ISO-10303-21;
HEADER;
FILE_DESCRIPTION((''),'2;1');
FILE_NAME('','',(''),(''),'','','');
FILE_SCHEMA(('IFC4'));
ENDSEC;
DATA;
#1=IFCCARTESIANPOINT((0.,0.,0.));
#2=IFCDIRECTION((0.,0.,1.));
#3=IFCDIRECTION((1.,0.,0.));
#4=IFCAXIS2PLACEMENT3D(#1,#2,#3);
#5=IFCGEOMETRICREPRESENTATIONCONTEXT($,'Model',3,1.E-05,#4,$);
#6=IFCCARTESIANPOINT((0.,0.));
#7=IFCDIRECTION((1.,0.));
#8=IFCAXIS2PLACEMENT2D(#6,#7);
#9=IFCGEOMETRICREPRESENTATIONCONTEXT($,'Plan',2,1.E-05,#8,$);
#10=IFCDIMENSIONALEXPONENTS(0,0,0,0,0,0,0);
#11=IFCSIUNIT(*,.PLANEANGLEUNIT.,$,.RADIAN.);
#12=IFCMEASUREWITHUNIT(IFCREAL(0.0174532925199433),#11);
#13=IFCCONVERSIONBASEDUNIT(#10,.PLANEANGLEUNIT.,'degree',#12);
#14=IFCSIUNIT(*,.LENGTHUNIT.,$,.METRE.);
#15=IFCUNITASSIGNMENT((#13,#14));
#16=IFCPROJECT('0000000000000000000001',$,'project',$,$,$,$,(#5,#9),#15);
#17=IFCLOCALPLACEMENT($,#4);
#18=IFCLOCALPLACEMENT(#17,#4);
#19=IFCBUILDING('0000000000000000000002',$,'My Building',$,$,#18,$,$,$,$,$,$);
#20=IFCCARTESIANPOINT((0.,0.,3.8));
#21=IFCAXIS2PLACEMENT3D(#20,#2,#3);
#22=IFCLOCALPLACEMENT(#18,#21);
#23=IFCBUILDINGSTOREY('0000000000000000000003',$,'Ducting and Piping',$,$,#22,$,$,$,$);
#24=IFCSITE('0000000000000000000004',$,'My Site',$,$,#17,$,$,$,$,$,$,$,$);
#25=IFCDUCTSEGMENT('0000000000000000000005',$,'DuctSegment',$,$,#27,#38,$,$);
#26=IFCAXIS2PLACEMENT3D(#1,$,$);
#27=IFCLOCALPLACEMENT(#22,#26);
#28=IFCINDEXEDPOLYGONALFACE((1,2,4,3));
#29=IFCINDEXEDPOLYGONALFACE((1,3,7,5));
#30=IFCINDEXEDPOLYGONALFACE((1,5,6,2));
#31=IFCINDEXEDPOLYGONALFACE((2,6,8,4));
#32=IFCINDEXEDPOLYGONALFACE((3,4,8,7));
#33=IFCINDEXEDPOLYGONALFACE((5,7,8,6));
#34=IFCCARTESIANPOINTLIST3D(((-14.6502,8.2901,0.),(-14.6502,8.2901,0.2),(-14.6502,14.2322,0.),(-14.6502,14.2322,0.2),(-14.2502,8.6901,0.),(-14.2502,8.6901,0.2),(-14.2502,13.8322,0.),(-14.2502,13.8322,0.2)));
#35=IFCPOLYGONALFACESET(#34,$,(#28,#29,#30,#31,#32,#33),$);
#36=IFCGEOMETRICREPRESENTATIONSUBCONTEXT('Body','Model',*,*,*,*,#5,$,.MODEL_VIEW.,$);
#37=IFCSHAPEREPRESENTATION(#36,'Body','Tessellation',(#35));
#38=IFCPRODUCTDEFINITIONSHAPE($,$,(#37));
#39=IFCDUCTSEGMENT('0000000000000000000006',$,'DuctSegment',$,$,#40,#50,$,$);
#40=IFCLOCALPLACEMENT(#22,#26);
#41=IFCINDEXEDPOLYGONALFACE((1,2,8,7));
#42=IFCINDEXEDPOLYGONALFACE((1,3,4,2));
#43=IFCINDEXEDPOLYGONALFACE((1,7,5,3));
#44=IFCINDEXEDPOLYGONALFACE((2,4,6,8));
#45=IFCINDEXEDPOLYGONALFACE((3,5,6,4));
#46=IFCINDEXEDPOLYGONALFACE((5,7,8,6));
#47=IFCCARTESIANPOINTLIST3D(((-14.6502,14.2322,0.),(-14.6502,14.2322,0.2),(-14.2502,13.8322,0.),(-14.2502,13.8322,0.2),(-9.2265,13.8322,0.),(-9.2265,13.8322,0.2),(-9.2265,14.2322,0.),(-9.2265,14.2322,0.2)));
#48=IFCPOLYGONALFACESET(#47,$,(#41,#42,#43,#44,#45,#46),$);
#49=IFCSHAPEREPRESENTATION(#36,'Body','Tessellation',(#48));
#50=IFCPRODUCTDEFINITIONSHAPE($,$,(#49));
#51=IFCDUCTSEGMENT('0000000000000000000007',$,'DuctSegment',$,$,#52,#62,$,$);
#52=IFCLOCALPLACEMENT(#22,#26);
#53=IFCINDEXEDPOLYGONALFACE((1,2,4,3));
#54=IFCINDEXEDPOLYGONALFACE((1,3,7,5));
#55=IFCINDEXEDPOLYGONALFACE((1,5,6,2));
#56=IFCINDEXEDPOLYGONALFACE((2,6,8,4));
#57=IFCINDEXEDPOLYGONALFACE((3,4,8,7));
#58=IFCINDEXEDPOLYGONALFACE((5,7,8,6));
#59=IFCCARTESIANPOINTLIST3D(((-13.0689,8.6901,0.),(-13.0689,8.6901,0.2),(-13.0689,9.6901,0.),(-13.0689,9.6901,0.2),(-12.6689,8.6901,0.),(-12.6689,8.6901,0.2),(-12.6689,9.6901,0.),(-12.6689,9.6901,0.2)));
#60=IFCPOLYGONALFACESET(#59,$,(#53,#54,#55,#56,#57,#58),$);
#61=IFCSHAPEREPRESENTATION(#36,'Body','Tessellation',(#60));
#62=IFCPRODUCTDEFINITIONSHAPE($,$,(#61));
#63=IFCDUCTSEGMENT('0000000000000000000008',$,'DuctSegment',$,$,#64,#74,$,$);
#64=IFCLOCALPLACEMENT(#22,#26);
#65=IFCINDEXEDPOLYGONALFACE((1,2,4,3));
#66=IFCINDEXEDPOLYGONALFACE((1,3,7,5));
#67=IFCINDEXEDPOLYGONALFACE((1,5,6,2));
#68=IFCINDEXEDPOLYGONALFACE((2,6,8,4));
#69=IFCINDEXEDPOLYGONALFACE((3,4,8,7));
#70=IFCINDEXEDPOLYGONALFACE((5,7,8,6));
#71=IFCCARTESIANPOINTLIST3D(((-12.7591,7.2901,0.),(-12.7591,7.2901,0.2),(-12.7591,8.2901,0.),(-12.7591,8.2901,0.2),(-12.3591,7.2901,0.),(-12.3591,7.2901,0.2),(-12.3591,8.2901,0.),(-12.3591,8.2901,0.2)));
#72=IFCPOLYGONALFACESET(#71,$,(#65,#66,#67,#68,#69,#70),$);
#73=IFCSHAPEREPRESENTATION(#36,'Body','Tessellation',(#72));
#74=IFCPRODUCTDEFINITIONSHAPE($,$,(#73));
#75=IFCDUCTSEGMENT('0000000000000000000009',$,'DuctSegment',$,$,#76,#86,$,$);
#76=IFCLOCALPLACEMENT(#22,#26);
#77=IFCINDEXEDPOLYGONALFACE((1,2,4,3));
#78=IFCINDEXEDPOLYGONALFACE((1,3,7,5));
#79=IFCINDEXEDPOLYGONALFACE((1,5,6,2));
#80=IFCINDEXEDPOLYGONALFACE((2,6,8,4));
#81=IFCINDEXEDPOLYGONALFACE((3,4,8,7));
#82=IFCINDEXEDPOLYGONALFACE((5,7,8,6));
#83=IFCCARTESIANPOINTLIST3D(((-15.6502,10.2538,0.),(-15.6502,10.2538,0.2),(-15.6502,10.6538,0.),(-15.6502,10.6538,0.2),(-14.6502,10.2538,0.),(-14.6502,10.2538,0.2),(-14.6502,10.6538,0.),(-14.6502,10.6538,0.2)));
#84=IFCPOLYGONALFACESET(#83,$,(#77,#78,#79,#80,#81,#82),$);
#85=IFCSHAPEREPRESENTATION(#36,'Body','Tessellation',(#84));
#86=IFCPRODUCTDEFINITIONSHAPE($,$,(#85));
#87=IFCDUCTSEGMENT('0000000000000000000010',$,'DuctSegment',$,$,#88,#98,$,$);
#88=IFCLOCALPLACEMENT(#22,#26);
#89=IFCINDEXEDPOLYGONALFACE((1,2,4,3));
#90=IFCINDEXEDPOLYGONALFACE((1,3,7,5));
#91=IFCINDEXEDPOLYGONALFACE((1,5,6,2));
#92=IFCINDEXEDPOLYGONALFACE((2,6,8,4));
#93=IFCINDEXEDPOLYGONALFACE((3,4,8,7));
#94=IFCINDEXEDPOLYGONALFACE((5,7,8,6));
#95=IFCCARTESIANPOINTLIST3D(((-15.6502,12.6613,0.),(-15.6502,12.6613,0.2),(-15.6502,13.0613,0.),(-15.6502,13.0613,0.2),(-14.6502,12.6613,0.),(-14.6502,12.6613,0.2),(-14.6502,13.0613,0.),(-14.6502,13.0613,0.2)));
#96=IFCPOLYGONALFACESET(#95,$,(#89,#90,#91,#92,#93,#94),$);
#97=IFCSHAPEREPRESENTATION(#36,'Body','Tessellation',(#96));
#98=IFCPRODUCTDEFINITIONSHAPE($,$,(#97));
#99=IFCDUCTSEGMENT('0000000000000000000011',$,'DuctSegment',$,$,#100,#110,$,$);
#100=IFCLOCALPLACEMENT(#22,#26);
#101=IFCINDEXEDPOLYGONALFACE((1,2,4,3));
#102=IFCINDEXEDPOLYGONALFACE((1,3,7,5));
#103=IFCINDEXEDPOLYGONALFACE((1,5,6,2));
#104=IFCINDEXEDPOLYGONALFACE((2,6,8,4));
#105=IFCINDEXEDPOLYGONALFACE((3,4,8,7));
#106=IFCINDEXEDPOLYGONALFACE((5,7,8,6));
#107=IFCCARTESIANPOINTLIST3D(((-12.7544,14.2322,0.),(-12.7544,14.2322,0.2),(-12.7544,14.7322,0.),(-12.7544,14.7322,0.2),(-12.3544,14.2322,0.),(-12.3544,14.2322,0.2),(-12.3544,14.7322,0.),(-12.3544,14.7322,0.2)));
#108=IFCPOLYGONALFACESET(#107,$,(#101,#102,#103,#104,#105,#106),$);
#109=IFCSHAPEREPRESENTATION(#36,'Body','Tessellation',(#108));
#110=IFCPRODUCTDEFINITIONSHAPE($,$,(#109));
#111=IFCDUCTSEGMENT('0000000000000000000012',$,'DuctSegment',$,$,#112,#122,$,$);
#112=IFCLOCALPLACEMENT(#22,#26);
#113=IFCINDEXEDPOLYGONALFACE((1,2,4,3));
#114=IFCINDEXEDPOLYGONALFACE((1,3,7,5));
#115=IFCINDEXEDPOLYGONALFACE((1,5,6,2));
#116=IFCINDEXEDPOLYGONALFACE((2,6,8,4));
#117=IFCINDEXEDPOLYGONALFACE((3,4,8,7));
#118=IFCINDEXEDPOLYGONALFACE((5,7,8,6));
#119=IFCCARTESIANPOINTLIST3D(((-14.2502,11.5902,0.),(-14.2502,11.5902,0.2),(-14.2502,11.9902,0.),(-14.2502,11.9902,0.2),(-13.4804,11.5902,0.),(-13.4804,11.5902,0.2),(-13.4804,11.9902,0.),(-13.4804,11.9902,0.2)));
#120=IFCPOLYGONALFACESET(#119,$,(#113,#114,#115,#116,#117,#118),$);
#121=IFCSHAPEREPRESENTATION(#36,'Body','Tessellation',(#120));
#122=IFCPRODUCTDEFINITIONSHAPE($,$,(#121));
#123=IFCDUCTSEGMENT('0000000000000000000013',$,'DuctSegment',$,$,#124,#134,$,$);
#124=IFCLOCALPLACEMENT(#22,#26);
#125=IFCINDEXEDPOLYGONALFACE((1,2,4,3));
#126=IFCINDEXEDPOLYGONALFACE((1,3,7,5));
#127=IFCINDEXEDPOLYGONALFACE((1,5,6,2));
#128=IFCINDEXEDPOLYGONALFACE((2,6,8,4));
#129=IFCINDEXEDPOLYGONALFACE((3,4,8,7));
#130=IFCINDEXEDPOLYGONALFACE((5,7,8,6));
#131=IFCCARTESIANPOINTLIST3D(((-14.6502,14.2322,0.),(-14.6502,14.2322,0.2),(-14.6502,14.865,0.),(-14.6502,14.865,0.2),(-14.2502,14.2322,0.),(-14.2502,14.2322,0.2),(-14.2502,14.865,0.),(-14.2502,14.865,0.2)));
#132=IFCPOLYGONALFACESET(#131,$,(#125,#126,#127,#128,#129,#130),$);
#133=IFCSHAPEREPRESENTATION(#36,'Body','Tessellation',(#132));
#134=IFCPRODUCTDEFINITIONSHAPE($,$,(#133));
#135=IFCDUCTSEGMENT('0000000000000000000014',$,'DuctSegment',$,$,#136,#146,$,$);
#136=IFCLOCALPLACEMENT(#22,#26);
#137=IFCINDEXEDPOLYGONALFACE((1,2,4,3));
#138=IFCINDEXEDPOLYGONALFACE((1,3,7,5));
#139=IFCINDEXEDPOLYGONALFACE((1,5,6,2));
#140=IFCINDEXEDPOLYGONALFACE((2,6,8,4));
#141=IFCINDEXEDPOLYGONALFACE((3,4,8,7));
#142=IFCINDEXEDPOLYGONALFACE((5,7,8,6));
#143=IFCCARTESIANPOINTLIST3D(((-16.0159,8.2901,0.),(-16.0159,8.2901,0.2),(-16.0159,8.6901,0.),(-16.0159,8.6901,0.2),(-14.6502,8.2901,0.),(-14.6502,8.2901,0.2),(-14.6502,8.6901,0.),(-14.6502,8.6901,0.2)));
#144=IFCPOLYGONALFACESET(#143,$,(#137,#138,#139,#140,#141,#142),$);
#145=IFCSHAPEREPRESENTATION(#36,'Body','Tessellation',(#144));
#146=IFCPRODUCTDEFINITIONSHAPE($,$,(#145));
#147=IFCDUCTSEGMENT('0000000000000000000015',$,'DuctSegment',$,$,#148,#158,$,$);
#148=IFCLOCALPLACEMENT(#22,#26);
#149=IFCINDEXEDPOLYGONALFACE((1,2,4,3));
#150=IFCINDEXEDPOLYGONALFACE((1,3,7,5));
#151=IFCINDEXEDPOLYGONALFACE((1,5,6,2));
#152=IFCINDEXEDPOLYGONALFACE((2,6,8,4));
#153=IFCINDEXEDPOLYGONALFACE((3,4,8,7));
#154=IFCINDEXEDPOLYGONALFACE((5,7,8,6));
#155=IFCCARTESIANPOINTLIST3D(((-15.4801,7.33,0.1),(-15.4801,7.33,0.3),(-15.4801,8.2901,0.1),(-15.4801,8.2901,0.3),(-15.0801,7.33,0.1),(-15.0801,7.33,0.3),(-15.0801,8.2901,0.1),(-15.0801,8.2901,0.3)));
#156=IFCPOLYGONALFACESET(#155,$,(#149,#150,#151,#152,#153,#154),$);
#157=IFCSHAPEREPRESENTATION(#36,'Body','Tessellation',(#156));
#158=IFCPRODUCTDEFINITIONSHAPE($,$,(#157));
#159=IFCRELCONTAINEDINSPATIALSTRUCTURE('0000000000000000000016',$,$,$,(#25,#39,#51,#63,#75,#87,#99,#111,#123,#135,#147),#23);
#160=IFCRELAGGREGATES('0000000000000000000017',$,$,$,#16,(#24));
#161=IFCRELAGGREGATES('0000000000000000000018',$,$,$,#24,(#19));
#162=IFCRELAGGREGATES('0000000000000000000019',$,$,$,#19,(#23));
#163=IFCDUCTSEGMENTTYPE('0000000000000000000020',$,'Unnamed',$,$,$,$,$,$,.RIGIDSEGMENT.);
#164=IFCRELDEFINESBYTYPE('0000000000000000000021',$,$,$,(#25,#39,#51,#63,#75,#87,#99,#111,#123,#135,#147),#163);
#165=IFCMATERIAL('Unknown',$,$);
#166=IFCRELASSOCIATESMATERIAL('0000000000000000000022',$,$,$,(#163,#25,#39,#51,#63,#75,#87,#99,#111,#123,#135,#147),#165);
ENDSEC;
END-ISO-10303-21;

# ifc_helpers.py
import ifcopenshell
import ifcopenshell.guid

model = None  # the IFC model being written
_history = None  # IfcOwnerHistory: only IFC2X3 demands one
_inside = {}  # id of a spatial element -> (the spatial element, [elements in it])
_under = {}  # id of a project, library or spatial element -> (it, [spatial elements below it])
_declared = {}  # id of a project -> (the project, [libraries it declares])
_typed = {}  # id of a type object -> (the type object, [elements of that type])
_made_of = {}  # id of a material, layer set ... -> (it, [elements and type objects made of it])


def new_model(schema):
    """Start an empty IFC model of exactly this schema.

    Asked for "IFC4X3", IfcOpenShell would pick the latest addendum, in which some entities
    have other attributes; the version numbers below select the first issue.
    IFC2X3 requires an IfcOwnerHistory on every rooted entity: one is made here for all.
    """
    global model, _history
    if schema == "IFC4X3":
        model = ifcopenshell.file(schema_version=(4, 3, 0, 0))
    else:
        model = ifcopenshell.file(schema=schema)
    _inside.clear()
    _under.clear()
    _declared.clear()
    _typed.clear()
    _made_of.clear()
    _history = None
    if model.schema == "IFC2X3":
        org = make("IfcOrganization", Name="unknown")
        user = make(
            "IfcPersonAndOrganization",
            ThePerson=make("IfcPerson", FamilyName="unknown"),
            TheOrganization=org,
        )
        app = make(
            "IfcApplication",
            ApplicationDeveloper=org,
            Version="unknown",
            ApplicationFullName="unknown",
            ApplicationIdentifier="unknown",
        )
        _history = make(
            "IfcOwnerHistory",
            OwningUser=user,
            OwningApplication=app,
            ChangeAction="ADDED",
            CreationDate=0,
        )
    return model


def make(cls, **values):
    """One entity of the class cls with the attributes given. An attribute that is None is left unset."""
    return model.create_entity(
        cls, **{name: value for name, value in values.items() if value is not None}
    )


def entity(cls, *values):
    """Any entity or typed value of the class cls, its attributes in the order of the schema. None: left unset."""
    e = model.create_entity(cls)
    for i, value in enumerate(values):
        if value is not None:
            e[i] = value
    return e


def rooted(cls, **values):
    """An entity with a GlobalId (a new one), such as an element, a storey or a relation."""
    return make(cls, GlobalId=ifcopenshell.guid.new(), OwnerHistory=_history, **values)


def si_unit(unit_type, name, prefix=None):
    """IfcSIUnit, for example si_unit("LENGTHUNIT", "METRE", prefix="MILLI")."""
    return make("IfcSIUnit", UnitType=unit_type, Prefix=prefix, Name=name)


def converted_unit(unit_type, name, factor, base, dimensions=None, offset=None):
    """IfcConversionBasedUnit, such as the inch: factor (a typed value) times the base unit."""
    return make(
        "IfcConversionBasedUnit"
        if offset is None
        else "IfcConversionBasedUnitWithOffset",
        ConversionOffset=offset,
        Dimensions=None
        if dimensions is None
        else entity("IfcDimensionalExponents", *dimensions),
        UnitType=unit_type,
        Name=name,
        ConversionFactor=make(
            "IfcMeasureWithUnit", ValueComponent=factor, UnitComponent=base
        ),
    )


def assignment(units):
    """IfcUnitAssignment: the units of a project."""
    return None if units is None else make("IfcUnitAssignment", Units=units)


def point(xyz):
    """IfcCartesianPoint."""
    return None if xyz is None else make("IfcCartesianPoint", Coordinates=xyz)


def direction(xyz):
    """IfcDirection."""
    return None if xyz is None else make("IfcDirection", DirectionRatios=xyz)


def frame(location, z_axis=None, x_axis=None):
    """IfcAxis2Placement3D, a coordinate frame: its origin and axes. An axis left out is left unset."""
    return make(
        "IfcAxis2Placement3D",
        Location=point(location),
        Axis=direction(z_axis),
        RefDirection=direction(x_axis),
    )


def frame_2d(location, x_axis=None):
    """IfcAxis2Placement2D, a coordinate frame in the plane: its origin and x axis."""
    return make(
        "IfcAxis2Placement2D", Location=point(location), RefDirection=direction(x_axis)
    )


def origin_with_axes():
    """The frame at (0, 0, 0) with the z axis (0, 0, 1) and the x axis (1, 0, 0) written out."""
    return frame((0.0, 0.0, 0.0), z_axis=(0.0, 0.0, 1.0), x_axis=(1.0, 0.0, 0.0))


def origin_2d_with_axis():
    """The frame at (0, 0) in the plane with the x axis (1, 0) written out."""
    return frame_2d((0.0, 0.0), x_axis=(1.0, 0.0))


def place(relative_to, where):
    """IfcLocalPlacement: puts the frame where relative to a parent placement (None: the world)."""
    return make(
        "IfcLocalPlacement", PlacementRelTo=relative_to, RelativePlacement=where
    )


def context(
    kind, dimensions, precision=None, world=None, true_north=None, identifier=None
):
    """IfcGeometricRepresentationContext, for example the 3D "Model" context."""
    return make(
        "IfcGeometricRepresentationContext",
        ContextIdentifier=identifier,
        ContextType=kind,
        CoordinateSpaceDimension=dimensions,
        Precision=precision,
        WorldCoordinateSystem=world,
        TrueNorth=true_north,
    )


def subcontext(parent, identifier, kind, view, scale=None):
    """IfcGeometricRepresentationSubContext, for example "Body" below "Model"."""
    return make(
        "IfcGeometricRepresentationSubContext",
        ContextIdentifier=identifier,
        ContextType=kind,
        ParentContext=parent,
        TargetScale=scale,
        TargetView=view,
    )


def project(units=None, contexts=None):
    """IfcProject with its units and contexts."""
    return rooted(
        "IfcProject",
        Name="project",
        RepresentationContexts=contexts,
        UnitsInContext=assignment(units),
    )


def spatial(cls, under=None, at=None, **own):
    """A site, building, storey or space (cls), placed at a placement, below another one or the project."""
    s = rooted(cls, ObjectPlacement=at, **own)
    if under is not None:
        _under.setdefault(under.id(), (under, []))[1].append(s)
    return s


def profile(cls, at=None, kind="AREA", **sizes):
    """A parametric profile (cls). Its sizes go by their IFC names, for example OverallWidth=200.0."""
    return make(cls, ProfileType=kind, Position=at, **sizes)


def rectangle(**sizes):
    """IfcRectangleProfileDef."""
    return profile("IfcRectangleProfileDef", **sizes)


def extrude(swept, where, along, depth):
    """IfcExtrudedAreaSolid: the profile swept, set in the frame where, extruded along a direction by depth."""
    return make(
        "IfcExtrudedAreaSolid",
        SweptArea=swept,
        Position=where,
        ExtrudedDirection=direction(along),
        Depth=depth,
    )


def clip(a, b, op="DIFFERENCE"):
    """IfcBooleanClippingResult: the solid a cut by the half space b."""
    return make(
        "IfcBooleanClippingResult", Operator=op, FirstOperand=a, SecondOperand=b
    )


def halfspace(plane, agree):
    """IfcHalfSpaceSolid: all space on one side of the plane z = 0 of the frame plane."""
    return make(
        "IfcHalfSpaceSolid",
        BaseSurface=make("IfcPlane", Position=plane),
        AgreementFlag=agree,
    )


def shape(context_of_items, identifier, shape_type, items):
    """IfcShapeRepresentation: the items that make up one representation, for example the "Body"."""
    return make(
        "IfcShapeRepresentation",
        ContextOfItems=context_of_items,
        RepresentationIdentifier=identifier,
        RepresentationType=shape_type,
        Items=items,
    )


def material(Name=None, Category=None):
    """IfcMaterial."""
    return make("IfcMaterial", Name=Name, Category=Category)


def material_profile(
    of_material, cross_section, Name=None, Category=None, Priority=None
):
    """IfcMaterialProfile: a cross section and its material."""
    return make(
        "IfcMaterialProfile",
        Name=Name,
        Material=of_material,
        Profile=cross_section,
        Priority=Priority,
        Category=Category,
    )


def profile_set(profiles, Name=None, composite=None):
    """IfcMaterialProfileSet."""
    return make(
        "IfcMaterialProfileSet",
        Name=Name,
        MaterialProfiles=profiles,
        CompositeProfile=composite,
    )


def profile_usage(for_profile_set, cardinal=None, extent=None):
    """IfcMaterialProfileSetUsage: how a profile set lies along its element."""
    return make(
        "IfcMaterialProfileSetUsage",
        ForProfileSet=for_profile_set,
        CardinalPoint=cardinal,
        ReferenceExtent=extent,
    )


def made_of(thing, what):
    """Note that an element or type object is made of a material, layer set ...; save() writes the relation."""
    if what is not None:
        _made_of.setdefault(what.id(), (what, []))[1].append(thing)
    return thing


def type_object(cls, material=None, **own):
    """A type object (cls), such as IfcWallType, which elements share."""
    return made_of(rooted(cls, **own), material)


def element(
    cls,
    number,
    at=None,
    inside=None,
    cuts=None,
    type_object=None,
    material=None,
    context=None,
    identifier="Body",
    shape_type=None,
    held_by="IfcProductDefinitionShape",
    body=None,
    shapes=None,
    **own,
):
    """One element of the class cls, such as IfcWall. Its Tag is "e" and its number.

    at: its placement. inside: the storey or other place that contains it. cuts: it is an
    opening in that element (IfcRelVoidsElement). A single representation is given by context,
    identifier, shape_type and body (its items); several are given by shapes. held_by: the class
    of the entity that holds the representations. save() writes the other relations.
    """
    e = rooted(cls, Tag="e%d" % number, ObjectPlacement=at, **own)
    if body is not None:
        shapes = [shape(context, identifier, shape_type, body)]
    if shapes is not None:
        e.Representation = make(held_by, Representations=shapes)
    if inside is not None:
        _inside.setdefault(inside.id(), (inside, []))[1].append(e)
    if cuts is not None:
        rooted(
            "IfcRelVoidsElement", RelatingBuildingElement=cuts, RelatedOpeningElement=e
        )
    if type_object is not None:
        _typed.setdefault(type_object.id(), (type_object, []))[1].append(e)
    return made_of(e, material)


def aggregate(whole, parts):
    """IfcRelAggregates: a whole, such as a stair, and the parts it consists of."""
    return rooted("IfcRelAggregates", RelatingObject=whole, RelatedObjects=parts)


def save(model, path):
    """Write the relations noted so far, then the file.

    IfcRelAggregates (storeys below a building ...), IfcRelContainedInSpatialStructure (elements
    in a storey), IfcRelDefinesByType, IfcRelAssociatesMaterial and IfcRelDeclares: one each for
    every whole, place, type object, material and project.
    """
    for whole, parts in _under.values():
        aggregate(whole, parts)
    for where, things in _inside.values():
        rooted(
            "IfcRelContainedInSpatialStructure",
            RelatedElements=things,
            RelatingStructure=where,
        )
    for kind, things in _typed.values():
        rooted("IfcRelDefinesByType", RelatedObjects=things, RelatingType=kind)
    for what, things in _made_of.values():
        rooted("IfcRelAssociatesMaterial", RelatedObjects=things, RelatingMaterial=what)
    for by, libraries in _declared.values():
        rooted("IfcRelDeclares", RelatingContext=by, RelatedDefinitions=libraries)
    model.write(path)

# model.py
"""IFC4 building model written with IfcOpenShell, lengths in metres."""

from ifc_helpers import new_model, entity, si_unit, converted_unit, frame, origin_with_axes, origin_2d_with_axis, place, context, subcontext, project, spatial, rectangle, extrude, clip, halfspace, material, material_profile, profile_set, profile_usage, type_object, element, save


model = new_model("IFC4")

# Units and contexts
model_context = context("Model", 3, precision=1e-05, world=origin_with_axes())
plan_context = context("Plan", 2, precision=1e-05, world=origin_2d_with_axis())
body_context = subcontext(model_context, "Body", "Model", "MODEL_VIEW")
ifc_project = project(units=[converted_unit("PLANEANGLEUNIT", "degree", entity("IfcReal", 0.0174532925199433), si_unit("PLANEANGLEUNIT", "RADIAN"), dimensions=[0, 0, 0, 0, 0, 0, 0]), si_unit("LENGTHUNIT", "METRE")], contexts=[model_context, plan_context])

# Site, building, storey
site_placement = place(None, origin_with_axes())
site = spatial("IfcSite", under=ifc_project, at=site_placement, Name="My Site")
building_placement = place(site_placement, origin_with_axes())
building = spatial("IfcBuilding", under=site, at=building_placement, Name="My Building")
storey_placement = place(building_placement, frame((0.0, 0.0, 3.8), z_axis=(0.0, 0.0, 1.0), x_axis=(1.0, 0.0, 0.0)))
storey = spatial("IfcBuildingStorey", under=building, at=storey_placement, Name="Ducting and Piping")

# Shared definitions
ifc_material = material(Name="Unknown")

# Duct segments
ifc_material_profile_1 = material_profile(ifc_material, rectangle(XDim=0.4, YDim=0.2))
ifc_profile_set_1 = profile_set([ifc_material_profile_1])
ifc_profile_usage_1 = profile_usage(ifc_profile_set_1, cardinal=5)
duct_segment_type = type_object("IfcDuctSegmentType", Name="Unnamed", PredefinedType="RIGIDSEGMENT", material=ifc_profile_set_1)
duct_segment_1_placement = place(storey_placement, frame((-14.4502, 8.2901, 0.1), z_axis=(0.0, 1.0, 0.0), x_axis=(-1.0, 0.0, 0.0)))
element("IfcDuctSegment", 1, at=duct_segment_1_placement, inside=storey, type_object=duct_segment_type, material=ifc_profile_usage_1, Name="DuctSegment", context=body_context, shape_type="Clipping", body=[
    clip(clip(extrude(rectangle(XDim=0.4, YDim=0.2), origin_with_axes(), (0.0, 0.0, 1.0), 5.9421), halfspace(frame((0.2, 0.0, 5.9421), z_axis=(-0.707107, 0.0, 0.707107), x_axis=(0.0, 1.0, 0.0)), False)), halfspace(frame((0.2, 0.0, 0.0), z_axis=(-0.707107, 0.0, -0.707107), x_axis=(0.0, 1.0, 0.0)), False)),
])
ifc_profile_usage_2 = profile_usage(ifc_profile_set_1, cardinal=5)
duct_segment_2_placement = place(storey_placement, frame((-14.6502, 14.0322, 0.1), z_axis=(1.0, 0.0, 0.0), x_axis=(0.0, 1.0, 0.0)))
element("IfcDuctSegment", 2, at=duct_segment_2_placement, inside=storey, type_object=duct_segment_type, material=ifc_profile_usage_2, Name="DuctSegment", context=body_context, shape_type="Clipping", body=[
    clip(extrude(rectangle(XDim=0.4, YDim=0.2), origin_with_axes(), (0.0, 0.0, 1.0), 5.4238), halfspace(frame((0.2, 0.0, 0.0), z_axis=(-0.707107, 0.0, -0.707107), x_axis=(0.0, 1.0, 0.0)), False)),
])
ifc_profile_usage_3 = profile_usage(ifc_profile_set_1, cardinal=5)
duct_segment_3_placement = place(storey_placement, frame((-12.8689, 8.6901, 0.1), z_axis=(0.0, 1.0, 0.0), x_axis=(-1.0, 0.0, 0.0)))
element("IfcDuctSegment", 3, at=duct_segment_3_placement, inside=storey, type_object=duct_segment_type, material=ifc_profile_usage_3, Name="DuctSegment", context=body_context, shape_type="SweptSolid", body=[
    extrude(rectangle(XDim=0.4, YDim=0.2), origin_with_axes(), (0.0, 0.0, 1.0), 1.0),
])
ifc_profile_usage_4 = profile_usage(ifc_profile_set_1, cardinal=5)
duct_segment_4_placement = place(storey_placement, frame((-12.5591, 8.2901, 0.1), z_axis=(0.0, -1.0, 0.0), x_axis=(1.0, 0.0, 0.0)))
element("IfcDuctSegment", 4, at=duct_segment_4_placement, inside=storey, type_object=duct_segment_type, material=ifc_profile_usage_4, Name="DuctSegment", context=body_context, shape_type="SweptSolid", body=[
    extrude(rectangle(XDim=0.4, YDim=0.2), origin_with_axes(), (0.0, 0.0, 1.0), 1.0),
])
ifc_profile_usage_5 = profile_usage(ifc_profile_set_1, cardinal=5)
duct_segment_5_placement = place(storey_placement, frame((-14.6502, 10.4538, 0.1), z_axis=(-1.0, 0.0, 0.0), x_axis=(0.0, -1.0, 0.0)))
element("IfcDuctSegment", 5, at=duct_segment_5_placement, inside=storey, type_object=duct_segment_type, material=ifc_profile_usage_5, Name="DuctSegment", context=body_context, shape_type="SweptSolid", body=[
    extrude(rectangle(XDim=0.4, YDim=0.2), origin_with_axes(), (0.0, 0.0, 1.0), 1.0),
])
ifc_profile_usage_6 = profile_usage(ifc_profile_set_1, cardinal=5)
duct_segment_6_placement = place(storey_placement, frame((-14.6502, 12.8613, 0.1), z_axis=(-1.0, 0.0, 0.0), x_axis=(0.0, -1.0, 0.0)))
element("IfcDuctSegment", 6, at=duct_segment_6_placement, inside=storey, type_object=duct_segment_type, material=ifc_profile_usage_6, Name="DuctSegment", context=body_context, shape_type="SweptSolid", body=[
    extrude(rectangle(XDim=0.4, YDim=0.2), origin_with_axes(), (0.0, 0.0, 1.0), 1.0),
])
ifc_profile_usage_7 = profile_usage(ifc_profile_set_1, cardinal=5)
duct_segment_7_placement = place(storey_placement, frame((-12.5544, 14.2322, 0.1), z_axis=(0.0, 1.0, 0.0), x_axis=(-1.0, 0.0, 0.0)))
element("IfcDuctSegment", 7, at=duct_segment_7_placement, inside=storey, type_object=duct_segment_type, material=ifc_profile_usage_7, Name="DuctSegment", context=body_context, shape_type="SweptSolid", body=[
    extrude(rectangle(XDim=0.4, YDim=0.2), origin_with_axes(), (0.0, 0.0, 1.0), 0.5),
])
ifc_profile_usage_8 = profile_usage(ifc_profile_set_1, cardinal=5)
duct_segment_8_placement = place(storey_placement, frame((-14.2502, 11.7902, 0.1), z_axis=(1.0, 0.0, 0.0), x_axis=(0.0, 1.0, 0.0)))
element("IfcDuctSegment", 8, at=duct_segment_8_placement, inside=storey, type_object=duct_segment_type, material=ifc_profile_usage_8, Name="DuctSegment", context=body_context, shape_type="SweptSolid", body=[
    extrude(rectangle(XDim=0.4, YDim=0.2), origin_with_axes(), (0.0, 0.0, 1.0), 0.7698),
])
ifc_profile_usage_9 = profile_usage(ifc_profile_set_1, cardinal=5)
duct_segment_9_placement = place(storey_placement, frame((-14.4502, 14.2322, 0.1), z_axis=(0.0, 1.0, 0.0), x_axis=(-1.0, 0.0, 0.0)))
element("IfcDuctSegment", 9, at=duct_segment_9_placement, inside=storey, type_object=duct_segment_type, material=ifc_profile_usage_9, Name="DuctSegment", context=body_context, shape_type="SweptSolid", body=[
    extrude(rectangle(XDim=0.4, YDim=0.2), origin_with_axes(), (0.0, 0.0, 1.0), 0.6328),
])
ifc_profile_usage_10 = profile_usage(ifc_profile_set_1, cardinal=5)
duct_segment_10_placement = place(storey_placement, frame((-14.6502, 8.4901, 0.1), z_axis=(-1.0, -0.000001, 0.000001), x_axis=(0.000001, -1.0, 0.0)))
element("IfcDuctSegment", 10, at=duct_segment_10_placement, inside=storey, type_object=duct_segment_type, material=ifc_profile_usage_10, Name="DuctSegment", context=body_context, shape_type="SweptSolid", body=[
    extrude(rectangle(XDim=0.4, YDim=0.2), origin_with_axes(), (0.0, 0.0, 1.0), 1.3656),
])
ifc_profile_usage_11 = profile_usage(ifc_profile_set_1, cardinal=5)
duct_segment_11_placement = place(storey_placement, frame((-15.2801, 8.2901, 0.2), z_axis=(0.0, -1.0, 0.0), x_axis=(1.0, 0.0, 0.0)))
element("IfcDuctSegment", 11, at=duct_segment_11_placement, inside=storey, type_object=duct_segment_type, material=ifc_profile_usage_11, Name="DuctSegment", context=body_context, shape_type="SweptSolid", body=[
    extrude(rectangle(XDim=0.4, YDim=0.2), origin_with_axes(), (0.0, 0.0, 1.0), 0.9601),
])

save(model, "model.ifc")
